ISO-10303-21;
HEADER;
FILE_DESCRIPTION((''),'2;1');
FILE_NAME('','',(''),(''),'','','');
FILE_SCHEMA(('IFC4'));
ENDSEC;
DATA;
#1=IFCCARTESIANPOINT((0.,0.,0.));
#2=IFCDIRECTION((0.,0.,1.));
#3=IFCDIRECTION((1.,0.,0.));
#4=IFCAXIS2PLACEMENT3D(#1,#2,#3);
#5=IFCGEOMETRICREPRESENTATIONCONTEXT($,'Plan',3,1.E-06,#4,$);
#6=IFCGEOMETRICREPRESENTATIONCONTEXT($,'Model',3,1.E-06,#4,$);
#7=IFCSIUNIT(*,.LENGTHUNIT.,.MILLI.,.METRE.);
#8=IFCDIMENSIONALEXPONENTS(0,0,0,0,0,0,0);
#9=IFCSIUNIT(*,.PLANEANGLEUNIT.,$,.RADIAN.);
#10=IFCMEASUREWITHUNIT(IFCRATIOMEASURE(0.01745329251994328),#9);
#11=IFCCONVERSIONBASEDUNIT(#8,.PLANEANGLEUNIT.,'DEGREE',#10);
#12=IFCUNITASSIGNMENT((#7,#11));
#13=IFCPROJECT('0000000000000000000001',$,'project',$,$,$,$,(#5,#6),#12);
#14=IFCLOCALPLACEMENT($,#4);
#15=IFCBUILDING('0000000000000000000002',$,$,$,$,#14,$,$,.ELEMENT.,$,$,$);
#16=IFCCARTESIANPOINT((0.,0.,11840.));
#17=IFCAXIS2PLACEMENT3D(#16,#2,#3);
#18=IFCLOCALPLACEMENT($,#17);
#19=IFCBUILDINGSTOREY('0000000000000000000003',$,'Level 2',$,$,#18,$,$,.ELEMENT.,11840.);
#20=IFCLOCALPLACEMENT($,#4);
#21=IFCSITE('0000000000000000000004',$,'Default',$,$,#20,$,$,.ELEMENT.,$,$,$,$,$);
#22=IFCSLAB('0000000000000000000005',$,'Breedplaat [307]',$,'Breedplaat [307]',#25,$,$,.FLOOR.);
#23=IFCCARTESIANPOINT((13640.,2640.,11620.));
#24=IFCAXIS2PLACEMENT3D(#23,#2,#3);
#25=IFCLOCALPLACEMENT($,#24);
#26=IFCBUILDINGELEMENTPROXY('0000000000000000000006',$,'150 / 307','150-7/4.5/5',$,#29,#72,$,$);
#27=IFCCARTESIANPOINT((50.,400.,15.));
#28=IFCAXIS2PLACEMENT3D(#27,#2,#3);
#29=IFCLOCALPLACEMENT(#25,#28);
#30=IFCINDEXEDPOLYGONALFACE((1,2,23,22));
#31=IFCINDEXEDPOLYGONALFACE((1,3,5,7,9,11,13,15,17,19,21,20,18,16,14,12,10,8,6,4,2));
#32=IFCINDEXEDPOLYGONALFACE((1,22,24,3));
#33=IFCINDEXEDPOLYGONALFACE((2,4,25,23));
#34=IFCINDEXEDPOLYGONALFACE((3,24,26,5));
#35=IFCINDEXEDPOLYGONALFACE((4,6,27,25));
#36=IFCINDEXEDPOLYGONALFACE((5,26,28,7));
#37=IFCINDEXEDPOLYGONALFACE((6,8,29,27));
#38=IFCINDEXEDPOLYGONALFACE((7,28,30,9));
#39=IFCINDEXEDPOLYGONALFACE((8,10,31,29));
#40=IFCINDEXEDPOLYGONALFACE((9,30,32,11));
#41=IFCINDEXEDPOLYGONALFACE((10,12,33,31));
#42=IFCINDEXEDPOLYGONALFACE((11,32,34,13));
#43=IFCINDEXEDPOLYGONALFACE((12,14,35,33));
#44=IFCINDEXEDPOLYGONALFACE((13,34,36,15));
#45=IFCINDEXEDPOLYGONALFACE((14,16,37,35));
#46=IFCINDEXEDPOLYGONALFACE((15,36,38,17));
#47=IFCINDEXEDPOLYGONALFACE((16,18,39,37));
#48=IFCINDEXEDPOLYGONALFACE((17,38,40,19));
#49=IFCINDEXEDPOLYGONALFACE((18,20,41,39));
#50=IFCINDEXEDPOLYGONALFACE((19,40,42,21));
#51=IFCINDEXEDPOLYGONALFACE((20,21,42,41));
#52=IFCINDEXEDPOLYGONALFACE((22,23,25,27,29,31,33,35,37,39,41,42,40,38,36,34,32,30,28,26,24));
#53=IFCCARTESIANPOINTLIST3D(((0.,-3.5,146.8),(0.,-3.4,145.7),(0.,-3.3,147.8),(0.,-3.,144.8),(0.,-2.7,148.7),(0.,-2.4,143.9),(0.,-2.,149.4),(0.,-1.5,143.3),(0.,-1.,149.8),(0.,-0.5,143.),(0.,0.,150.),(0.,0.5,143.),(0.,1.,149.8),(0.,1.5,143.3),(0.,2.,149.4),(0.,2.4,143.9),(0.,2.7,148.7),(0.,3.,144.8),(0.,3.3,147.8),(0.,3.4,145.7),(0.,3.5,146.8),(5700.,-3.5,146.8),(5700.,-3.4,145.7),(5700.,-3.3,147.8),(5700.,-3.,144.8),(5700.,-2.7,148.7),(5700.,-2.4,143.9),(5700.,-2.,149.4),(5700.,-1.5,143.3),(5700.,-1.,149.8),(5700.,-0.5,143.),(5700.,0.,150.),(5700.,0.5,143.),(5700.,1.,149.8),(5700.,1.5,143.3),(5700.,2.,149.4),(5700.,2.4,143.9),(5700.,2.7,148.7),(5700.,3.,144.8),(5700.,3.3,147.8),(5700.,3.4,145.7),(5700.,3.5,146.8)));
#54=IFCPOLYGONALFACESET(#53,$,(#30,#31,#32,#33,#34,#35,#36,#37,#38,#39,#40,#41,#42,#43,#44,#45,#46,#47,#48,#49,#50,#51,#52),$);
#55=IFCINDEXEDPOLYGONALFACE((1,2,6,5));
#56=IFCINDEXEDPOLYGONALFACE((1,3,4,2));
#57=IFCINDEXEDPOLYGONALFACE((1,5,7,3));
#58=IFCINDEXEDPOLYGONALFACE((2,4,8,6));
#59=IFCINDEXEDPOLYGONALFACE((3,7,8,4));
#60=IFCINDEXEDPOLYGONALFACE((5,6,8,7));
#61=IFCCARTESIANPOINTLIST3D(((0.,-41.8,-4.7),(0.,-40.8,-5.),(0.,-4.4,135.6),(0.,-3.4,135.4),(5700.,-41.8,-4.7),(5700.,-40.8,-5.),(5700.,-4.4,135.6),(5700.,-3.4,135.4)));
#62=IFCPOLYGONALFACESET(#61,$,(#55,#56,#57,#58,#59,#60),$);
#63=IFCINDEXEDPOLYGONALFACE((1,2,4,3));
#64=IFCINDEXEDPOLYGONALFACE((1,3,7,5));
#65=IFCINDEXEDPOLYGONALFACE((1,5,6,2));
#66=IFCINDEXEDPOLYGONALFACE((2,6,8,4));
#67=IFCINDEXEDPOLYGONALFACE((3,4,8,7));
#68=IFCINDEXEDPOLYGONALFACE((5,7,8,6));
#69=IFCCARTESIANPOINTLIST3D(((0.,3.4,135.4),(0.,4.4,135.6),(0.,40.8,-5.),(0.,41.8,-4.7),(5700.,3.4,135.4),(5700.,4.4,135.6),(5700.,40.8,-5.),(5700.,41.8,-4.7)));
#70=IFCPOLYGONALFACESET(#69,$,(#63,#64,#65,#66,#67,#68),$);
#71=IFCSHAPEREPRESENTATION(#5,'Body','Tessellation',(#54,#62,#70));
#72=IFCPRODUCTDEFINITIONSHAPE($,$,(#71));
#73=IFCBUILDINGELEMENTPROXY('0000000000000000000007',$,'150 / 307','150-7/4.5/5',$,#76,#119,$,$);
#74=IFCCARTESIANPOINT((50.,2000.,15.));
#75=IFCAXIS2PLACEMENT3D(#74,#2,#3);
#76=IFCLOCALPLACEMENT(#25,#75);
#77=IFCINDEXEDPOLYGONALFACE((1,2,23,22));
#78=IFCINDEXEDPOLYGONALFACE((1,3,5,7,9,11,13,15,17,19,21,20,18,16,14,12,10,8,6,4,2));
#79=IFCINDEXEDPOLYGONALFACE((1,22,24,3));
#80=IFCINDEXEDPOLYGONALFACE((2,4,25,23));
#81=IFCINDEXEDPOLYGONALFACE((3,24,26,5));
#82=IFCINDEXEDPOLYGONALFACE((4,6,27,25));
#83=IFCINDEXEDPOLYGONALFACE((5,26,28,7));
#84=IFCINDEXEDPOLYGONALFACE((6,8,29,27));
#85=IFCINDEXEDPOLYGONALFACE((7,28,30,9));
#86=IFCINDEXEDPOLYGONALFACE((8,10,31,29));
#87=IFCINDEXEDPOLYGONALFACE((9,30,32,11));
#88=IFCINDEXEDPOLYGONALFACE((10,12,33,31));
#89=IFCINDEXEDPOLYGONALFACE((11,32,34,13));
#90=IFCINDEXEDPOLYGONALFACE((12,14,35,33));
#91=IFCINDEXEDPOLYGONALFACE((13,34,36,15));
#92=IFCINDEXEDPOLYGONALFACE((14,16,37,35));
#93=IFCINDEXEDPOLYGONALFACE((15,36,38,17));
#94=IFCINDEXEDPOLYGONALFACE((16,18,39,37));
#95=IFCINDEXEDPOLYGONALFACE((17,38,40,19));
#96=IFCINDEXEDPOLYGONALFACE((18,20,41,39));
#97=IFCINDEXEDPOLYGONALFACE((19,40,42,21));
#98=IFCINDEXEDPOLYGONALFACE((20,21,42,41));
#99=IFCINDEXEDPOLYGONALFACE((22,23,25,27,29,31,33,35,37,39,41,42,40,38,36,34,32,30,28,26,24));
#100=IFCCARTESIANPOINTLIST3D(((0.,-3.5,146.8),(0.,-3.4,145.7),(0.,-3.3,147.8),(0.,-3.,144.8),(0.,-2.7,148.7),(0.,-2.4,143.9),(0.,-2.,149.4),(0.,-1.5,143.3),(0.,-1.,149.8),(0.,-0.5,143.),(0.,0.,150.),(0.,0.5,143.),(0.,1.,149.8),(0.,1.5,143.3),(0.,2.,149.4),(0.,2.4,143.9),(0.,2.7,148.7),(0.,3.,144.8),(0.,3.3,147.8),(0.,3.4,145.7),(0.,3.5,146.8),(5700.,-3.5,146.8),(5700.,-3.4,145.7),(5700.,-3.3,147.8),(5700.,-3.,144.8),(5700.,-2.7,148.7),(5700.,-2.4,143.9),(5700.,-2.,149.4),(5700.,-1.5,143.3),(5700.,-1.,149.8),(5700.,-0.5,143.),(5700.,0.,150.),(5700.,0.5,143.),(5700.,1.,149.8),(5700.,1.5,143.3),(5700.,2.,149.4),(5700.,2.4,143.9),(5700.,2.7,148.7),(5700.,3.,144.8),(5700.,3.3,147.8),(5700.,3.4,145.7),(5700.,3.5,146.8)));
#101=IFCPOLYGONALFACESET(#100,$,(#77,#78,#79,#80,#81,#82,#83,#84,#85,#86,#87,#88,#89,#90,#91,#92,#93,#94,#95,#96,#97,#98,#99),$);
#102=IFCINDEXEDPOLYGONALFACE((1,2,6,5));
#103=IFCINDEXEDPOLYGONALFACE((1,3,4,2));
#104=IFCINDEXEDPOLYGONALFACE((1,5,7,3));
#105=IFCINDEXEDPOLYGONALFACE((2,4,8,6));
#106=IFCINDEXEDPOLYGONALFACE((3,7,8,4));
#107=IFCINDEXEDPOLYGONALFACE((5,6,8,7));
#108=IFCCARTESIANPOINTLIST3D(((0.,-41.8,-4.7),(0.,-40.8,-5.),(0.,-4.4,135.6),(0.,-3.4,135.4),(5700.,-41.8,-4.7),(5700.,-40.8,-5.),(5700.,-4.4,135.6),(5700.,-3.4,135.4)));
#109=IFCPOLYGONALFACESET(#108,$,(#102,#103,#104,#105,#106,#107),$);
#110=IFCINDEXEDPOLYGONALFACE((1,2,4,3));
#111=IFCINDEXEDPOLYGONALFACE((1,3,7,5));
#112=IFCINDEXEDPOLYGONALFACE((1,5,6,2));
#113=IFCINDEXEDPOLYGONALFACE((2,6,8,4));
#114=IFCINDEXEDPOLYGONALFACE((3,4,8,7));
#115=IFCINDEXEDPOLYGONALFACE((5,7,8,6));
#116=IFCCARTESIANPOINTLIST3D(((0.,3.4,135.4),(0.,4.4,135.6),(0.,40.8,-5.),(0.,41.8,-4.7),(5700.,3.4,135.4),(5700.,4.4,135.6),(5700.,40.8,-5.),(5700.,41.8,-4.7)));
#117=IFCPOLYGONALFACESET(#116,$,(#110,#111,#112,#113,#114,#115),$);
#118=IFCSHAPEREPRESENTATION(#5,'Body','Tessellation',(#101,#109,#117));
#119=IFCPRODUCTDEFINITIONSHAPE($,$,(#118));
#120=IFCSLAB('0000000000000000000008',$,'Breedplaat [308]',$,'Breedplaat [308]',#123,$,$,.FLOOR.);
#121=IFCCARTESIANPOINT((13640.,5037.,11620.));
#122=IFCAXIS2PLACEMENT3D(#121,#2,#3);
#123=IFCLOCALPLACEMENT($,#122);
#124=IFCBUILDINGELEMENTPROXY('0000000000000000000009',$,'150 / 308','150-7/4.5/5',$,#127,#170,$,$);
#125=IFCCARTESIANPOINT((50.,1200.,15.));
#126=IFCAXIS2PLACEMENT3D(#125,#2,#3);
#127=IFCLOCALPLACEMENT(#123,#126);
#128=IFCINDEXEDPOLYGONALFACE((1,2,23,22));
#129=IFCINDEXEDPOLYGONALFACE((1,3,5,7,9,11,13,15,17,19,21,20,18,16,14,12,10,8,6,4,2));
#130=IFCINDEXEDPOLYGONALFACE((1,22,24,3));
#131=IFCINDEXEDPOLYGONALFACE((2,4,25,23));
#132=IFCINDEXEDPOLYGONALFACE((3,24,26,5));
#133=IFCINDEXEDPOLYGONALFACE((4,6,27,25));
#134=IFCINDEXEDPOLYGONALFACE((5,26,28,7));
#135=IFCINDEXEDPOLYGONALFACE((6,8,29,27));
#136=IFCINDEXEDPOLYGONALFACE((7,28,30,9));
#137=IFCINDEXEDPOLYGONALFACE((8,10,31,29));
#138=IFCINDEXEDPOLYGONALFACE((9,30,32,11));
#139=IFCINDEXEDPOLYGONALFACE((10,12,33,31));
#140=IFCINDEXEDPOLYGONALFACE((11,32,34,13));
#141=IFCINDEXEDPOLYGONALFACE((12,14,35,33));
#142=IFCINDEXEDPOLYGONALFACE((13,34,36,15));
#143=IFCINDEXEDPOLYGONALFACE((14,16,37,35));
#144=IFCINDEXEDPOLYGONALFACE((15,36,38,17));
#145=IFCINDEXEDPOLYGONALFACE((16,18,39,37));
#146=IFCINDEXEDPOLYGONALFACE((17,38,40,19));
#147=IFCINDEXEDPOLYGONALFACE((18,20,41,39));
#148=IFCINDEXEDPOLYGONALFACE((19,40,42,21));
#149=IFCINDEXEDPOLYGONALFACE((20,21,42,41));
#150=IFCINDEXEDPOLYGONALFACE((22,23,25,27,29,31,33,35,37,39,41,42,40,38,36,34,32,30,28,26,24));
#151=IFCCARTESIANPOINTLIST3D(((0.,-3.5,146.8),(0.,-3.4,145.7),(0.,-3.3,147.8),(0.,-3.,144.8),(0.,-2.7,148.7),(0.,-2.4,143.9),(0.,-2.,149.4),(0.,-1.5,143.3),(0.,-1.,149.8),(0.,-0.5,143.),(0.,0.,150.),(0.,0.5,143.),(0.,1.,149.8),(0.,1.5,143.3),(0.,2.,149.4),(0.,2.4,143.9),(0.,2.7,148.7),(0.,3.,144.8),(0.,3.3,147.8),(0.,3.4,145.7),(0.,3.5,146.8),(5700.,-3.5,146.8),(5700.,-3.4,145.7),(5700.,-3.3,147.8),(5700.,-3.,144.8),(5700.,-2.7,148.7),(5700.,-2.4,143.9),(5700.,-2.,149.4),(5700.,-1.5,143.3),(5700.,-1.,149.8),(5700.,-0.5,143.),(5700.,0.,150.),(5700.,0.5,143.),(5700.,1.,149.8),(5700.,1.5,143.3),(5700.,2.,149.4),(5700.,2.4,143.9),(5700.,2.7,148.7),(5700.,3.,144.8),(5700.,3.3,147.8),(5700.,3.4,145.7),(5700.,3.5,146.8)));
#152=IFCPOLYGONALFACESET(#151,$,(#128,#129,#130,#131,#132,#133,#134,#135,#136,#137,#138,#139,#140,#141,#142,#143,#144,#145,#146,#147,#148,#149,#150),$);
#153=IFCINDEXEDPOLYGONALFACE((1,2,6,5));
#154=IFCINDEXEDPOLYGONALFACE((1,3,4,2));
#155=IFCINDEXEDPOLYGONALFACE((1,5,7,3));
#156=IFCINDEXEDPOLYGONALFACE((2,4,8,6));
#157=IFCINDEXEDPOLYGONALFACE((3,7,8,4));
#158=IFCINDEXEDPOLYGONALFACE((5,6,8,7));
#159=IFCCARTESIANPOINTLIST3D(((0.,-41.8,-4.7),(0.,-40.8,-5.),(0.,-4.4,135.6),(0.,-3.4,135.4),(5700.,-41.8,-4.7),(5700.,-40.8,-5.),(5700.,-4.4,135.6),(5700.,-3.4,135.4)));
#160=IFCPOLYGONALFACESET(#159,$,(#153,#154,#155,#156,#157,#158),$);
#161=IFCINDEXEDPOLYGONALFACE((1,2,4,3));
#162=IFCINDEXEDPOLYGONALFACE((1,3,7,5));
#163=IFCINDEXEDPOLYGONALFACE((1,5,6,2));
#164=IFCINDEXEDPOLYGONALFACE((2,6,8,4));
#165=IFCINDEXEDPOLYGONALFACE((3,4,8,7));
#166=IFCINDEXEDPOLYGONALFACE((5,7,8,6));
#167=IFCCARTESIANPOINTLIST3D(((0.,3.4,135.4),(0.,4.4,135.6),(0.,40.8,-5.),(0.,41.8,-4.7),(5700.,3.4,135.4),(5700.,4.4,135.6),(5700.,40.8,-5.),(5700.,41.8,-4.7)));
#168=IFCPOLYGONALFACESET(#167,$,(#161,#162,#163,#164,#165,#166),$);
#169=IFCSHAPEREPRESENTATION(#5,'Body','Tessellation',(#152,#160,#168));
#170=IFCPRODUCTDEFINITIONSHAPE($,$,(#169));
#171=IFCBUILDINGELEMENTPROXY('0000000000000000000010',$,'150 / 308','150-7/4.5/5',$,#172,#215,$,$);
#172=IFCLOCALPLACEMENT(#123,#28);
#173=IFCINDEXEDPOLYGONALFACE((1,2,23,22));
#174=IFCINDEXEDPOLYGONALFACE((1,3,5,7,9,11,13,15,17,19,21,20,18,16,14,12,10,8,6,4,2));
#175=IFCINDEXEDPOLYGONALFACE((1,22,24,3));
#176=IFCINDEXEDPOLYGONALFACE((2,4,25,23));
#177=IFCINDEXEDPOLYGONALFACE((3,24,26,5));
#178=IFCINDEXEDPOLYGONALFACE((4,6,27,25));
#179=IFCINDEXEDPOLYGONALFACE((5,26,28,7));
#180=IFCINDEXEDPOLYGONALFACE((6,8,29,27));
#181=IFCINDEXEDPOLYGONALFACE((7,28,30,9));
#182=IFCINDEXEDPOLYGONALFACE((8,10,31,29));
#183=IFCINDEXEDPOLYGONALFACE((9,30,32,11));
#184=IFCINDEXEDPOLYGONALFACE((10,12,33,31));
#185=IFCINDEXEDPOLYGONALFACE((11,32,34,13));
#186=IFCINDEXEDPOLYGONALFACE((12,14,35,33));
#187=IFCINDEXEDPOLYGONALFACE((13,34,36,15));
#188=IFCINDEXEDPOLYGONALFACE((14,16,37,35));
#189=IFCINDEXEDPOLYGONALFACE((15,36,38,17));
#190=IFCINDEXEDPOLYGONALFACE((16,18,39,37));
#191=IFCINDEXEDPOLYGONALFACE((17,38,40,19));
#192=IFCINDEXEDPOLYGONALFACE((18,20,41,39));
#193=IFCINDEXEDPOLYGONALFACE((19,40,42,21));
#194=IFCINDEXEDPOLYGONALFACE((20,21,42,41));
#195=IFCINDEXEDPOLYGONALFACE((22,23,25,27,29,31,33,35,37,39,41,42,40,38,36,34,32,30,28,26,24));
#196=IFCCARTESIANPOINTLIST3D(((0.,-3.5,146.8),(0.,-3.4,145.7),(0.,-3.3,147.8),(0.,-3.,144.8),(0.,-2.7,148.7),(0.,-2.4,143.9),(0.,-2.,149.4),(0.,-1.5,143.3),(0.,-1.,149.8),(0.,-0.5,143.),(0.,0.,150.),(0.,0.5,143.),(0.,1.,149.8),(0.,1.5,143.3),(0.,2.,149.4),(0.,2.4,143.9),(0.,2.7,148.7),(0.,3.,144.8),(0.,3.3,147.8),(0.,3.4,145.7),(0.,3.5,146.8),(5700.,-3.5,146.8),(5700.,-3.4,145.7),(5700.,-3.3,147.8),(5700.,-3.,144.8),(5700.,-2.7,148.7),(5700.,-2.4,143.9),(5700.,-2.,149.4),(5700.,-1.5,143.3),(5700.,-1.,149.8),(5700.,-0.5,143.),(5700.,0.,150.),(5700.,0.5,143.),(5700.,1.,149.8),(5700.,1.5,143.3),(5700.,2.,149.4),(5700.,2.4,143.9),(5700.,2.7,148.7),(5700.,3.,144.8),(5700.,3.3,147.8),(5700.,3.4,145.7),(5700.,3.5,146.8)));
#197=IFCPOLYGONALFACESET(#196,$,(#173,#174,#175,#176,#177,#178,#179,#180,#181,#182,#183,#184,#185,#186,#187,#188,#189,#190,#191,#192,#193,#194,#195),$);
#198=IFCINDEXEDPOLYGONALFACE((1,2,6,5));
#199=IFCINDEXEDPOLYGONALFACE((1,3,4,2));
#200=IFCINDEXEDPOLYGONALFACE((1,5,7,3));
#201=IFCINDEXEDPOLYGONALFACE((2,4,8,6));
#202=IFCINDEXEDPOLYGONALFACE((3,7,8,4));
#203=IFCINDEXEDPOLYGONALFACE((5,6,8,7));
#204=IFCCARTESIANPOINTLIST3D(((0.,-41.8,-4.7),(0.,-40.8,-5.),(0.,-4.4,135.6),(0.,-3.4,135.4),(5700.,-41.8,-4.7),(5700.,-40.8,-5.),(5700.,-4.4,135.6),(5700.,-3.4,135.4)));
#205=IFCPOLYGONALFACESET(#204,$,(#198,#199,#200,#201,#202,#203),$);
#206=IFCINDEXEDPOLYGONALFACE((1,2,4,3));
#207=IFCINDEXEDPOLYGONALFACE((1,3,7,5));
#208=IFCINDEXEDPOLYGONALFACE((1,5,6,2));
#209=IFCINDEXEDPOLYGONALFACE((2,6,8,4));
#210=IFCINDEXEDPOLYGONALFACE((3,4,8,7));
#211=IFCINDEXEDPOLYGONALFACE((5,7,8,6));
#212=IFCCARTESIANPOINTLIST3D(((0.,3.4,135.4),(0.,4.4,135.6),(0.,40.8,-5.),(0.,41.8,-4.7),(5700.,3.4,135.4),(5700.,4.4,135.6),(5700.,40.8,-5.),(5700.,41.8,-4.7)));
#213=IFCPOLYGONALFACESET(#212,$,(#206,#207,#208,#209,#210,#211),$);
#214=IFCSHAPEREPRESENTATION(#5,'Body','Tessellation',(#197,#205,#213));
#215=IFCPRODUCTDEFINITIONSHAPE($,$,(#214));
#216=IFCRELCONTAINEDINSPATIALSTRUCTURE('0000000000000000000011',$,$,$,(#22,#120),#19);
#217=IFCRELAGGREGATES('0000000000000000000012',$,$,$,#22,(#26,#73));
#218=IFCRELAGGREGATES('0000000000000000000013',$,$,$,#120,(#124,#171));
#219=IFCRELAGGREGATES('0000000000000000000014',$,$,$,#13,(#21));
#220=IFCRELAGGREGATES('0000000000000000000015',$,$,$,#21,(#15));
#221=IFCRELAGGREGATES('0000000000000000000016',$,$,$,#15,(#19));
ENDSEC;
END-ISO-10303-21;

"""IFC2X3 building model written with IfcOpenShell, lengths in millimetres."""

from ifc_helpers import new_model, entity, si_unit, converted_unit, frame, origin_with_axes, origin_2d_with_axis, place, context, project, spatial, rectangle, circle, extrude, element, aggregate, save


model = new_model("IFC2X3")

# Units and contexts
plan_context = context("Plan", 3, precision=1e-06, world=origin_with_axes())
model_context = context("Model", 3, precision=1e-06, world=origin_with_axes())
ifc_project = project(units=[si_unit("LENGTHUNIT", "METRE", prefix="MILLI"), converted_unit("PLANEANGLEUNIT", "DEGREE", entity("IfcRatioMeasure", 0.01745329251994328), si_unit("PLANEANGLEUNIT", "RADIAN"), dimensions=[0, 0, 0, 0, 0, 0, 0])], contexts=[plan_context, model_context])

# Site, building, storey
site_placement = place(None, origin_with_axes())
site = spatial("IfcSite", under=ifc_project, at=site_placement, Name="Default", CompositionType="ELEMENT")
building_placement = place(None, origin_with_axes())
building = spatial("IfcBuilding", under=site, at=building_placement, CompositionType="ELEMENT")
storey_placement = place(None, frame((0.0, 0.0, 11840.0), z_axis=(0.0, 0.0, 1.0), x_axis=(1.0, 0.0, 0.0)))
storey = spatial("IfcBuildingStorey", under=building, at=storey_placement, Name="Level 2", CompositionType="ELEMENT", Elevation=11840.0)

# Slabs, building element proxies
slab_1_placement = place(None, frame((13640.0, 2640.0, 11620.0), z_axis=(0.0, 0.0, 1.0), x_axis=(1.0, 0.0, 0.0)))
slab_1 = element("IfcSlab", 1, at=slab_1_placement, inside=storey, Name="Breedplaat [307]", ObjectType="Breedplaat [307]", PredefinedType="FLOOR")
proxy_1_placement = place(slab_1_placement, frame((50.0, 400.0, 15.0), z_axis=(0.0, 0.0, 1.0), x_axis=(1.0, 0.0, 0.0)))
proxy_1 = element("IfcBuildingElementProxy", 2, at=proxy_1_placement, Name="150 / 307", Description="150-7/4.5/5", context=plan_context, shape_type="SweptSolid", body=[
    extrude(circle(Radius=3.5, at=origin_2d_with_axis()), frame((0.0, 0.0, 146.5), z_axis=(1.0, 0.0, 0.0), x_axis=(0.0, 0.0, 1.0)), (0.0, 0.0, 1.0), 5700.0),
    extrude(rectangle(XDim=145.2, YDim=1.0, at=origin_2d_with_axis()), frame((0.0, -22.6, 65.3), z_axis=(1.0, 0.0, 0.0), x_axis=(0.0, 0.257663, 0.966235)), (0.0, 0.0, 1.0), 5700.0),
    extrude(rectangle(XDim=145.2, YDim=1.0, at=origin_2d_with_axis()), frame((0.0, 22.6, 65.3), z_axis=(1.0, 0.0, 0.0), x_axis=(0.0, -0.257663, 0.966235)), (0.0, 0.0, 1.0), 5700.0),
])
proxy_2_placement = place(slab_1_placement, frame((50.0, 2000.0, 15.0), z_axis=(0.0, 0.0, 1.0), x_axis=(1.0, 0.0, 0.0)))
proxy_2 = element("IfcBuildingElementProxy", 3, at=proxy_2_placement, Name="150 / 307", Description="150-7/4.5/5", context=plan_context, shape_type="SweptSolid", body=[
    extrude(circle(Radius=3.5, at=origin_2d_with_axis()), frame((0.0, 0.0, 146.5), z_axis=(1.0, 0.0, 0.0), x_axis=(0.0, 0.0, 1.0)), (0.0, 0.0, 1.0), 5700.0),
    extrude(rectangle(XDim=145.2, YDim=1.0, at=origin_2d_with_axis()), frame((0.0, -22.6, 65.3), z_axis=(1.0, 0.0, 0.0), x_axis=(0.0, 0.257663, 0.966235)), (0.0, 0.0, 1.0), 5700.0),
    extrude(rectangle(XDim=145.2, YDim=1.0, at=origin_2d_with_axis()), frame((0.0, 22.6, 65.3), z_axis=(1.0, 0.0, 0.0), x_axis=(0.0, -0.257663, 0.966235)), (0.0, 0.0, 1.0), 5700.0),
])
aggregate(slab_1, [proxy_1, proxy_2])
slab_2_placement = place(None, frame((13640.0, 5037.0, 11620.0), z_axis=(0.0, 0.0, 1.0), x_axis=(1.0, 0.0, 0.0)))
slab_2 = element("IfcSlab", 4, at=slab_2_placement, inside=storey, Name="Breedplaat [308]", ObjectType="Breedplaat [308]", PredefinedType="FLOOR")
proxy_3_placement = place(slab_2_placement, frame((50.0, 1200.0, 15.0), z_axis=(0.0, 0.0, 1.0), x_axis=(1.0, 0.0, 0.0)))
proxy_3 = element("IfcBuildingElementProxy", 5, at=proxy_3_placement, Name="150 / 308", Description="150-7/4.5/5", context=plan_context, shape_type="SweptSolid", body=[
    extrude(circle(Radius=3.5, at=origin_2d_with_axis()), frame((0.0, 0.0, 146.5), z_axis=(1.0, 0.0, 0.0), x_axis=(0.0, 0.0, 1.0)), (0.0, 0.0, 1.0), 5700.0),
    extrude(rectangle(XDim=145.2, YDim=1.0, at=origin_2d_with_axis()), frame((0.0, -22.6, 65.3), z_axis=(1.0, 0.0, 0.0), x_axis=(0.0, 0.257663, 0.966235)), (0.0, 0.0, 1.0), 5700.0),
    extrude(rectangle(XDim=145.2, YDim=1.0, at=origin_2d_with_axis()), frame((0.0, 22.6, 65.3), z_axis=(1.0, 0.0, 0.0), x_axis=(0.0, -0.257663, 0.966235)), (0.0, 0.0, 1.0), 5700.0),
])
proxy_4_placement = place(slab_2_placement, frame((50.0, 400.0, 15.0), z_axis=(0.0, 0.0, 1.0), x_axis=(1.0, 0.0, 0.0)))
proxy_4 = element("IfcBuildingElementProxy", 6, at=proxy_4_placement, Name="150 / 308", Description="150-7/4.5/5", context=plan_context, shape_type="SweptSolid", body=[
    extrude(circle(Radius=3.5, at=origin_2d_with_axis()), frame((0.0, 0.0, 146.5), z_axis=(1.0, 0.0, 0.0), x_axis=(0.0, 0.0, 1.0)), (0.0, 0.0, 1.0), 5700.0),
    extrude(rectangle(XDim=145.2, YDim=1.0, at=origin_2d_with_axis()), frame((0.0, -22.6, 65.3), z_axis=(1.0, 0.0, 0.0), x_axis=(0.0, 0.257663, 0.966235)), (0.0, 0.0, 1.0), 5700.0),
    extrude(rectangle(XDim=145.2, YDim=1.0, at=origin_2d_with_axis()), frame((0.0, 22.6, 65.3), z_axis=(1.0, 0.0, 0.0), x_axis=(0.0, -0.257663, 0.966235)), (0.0, 0.0, 1.0), 5700.0),
])
aggregate(slab_2, [proxy_3, proxy_4])

save(model, "model.ifc")
